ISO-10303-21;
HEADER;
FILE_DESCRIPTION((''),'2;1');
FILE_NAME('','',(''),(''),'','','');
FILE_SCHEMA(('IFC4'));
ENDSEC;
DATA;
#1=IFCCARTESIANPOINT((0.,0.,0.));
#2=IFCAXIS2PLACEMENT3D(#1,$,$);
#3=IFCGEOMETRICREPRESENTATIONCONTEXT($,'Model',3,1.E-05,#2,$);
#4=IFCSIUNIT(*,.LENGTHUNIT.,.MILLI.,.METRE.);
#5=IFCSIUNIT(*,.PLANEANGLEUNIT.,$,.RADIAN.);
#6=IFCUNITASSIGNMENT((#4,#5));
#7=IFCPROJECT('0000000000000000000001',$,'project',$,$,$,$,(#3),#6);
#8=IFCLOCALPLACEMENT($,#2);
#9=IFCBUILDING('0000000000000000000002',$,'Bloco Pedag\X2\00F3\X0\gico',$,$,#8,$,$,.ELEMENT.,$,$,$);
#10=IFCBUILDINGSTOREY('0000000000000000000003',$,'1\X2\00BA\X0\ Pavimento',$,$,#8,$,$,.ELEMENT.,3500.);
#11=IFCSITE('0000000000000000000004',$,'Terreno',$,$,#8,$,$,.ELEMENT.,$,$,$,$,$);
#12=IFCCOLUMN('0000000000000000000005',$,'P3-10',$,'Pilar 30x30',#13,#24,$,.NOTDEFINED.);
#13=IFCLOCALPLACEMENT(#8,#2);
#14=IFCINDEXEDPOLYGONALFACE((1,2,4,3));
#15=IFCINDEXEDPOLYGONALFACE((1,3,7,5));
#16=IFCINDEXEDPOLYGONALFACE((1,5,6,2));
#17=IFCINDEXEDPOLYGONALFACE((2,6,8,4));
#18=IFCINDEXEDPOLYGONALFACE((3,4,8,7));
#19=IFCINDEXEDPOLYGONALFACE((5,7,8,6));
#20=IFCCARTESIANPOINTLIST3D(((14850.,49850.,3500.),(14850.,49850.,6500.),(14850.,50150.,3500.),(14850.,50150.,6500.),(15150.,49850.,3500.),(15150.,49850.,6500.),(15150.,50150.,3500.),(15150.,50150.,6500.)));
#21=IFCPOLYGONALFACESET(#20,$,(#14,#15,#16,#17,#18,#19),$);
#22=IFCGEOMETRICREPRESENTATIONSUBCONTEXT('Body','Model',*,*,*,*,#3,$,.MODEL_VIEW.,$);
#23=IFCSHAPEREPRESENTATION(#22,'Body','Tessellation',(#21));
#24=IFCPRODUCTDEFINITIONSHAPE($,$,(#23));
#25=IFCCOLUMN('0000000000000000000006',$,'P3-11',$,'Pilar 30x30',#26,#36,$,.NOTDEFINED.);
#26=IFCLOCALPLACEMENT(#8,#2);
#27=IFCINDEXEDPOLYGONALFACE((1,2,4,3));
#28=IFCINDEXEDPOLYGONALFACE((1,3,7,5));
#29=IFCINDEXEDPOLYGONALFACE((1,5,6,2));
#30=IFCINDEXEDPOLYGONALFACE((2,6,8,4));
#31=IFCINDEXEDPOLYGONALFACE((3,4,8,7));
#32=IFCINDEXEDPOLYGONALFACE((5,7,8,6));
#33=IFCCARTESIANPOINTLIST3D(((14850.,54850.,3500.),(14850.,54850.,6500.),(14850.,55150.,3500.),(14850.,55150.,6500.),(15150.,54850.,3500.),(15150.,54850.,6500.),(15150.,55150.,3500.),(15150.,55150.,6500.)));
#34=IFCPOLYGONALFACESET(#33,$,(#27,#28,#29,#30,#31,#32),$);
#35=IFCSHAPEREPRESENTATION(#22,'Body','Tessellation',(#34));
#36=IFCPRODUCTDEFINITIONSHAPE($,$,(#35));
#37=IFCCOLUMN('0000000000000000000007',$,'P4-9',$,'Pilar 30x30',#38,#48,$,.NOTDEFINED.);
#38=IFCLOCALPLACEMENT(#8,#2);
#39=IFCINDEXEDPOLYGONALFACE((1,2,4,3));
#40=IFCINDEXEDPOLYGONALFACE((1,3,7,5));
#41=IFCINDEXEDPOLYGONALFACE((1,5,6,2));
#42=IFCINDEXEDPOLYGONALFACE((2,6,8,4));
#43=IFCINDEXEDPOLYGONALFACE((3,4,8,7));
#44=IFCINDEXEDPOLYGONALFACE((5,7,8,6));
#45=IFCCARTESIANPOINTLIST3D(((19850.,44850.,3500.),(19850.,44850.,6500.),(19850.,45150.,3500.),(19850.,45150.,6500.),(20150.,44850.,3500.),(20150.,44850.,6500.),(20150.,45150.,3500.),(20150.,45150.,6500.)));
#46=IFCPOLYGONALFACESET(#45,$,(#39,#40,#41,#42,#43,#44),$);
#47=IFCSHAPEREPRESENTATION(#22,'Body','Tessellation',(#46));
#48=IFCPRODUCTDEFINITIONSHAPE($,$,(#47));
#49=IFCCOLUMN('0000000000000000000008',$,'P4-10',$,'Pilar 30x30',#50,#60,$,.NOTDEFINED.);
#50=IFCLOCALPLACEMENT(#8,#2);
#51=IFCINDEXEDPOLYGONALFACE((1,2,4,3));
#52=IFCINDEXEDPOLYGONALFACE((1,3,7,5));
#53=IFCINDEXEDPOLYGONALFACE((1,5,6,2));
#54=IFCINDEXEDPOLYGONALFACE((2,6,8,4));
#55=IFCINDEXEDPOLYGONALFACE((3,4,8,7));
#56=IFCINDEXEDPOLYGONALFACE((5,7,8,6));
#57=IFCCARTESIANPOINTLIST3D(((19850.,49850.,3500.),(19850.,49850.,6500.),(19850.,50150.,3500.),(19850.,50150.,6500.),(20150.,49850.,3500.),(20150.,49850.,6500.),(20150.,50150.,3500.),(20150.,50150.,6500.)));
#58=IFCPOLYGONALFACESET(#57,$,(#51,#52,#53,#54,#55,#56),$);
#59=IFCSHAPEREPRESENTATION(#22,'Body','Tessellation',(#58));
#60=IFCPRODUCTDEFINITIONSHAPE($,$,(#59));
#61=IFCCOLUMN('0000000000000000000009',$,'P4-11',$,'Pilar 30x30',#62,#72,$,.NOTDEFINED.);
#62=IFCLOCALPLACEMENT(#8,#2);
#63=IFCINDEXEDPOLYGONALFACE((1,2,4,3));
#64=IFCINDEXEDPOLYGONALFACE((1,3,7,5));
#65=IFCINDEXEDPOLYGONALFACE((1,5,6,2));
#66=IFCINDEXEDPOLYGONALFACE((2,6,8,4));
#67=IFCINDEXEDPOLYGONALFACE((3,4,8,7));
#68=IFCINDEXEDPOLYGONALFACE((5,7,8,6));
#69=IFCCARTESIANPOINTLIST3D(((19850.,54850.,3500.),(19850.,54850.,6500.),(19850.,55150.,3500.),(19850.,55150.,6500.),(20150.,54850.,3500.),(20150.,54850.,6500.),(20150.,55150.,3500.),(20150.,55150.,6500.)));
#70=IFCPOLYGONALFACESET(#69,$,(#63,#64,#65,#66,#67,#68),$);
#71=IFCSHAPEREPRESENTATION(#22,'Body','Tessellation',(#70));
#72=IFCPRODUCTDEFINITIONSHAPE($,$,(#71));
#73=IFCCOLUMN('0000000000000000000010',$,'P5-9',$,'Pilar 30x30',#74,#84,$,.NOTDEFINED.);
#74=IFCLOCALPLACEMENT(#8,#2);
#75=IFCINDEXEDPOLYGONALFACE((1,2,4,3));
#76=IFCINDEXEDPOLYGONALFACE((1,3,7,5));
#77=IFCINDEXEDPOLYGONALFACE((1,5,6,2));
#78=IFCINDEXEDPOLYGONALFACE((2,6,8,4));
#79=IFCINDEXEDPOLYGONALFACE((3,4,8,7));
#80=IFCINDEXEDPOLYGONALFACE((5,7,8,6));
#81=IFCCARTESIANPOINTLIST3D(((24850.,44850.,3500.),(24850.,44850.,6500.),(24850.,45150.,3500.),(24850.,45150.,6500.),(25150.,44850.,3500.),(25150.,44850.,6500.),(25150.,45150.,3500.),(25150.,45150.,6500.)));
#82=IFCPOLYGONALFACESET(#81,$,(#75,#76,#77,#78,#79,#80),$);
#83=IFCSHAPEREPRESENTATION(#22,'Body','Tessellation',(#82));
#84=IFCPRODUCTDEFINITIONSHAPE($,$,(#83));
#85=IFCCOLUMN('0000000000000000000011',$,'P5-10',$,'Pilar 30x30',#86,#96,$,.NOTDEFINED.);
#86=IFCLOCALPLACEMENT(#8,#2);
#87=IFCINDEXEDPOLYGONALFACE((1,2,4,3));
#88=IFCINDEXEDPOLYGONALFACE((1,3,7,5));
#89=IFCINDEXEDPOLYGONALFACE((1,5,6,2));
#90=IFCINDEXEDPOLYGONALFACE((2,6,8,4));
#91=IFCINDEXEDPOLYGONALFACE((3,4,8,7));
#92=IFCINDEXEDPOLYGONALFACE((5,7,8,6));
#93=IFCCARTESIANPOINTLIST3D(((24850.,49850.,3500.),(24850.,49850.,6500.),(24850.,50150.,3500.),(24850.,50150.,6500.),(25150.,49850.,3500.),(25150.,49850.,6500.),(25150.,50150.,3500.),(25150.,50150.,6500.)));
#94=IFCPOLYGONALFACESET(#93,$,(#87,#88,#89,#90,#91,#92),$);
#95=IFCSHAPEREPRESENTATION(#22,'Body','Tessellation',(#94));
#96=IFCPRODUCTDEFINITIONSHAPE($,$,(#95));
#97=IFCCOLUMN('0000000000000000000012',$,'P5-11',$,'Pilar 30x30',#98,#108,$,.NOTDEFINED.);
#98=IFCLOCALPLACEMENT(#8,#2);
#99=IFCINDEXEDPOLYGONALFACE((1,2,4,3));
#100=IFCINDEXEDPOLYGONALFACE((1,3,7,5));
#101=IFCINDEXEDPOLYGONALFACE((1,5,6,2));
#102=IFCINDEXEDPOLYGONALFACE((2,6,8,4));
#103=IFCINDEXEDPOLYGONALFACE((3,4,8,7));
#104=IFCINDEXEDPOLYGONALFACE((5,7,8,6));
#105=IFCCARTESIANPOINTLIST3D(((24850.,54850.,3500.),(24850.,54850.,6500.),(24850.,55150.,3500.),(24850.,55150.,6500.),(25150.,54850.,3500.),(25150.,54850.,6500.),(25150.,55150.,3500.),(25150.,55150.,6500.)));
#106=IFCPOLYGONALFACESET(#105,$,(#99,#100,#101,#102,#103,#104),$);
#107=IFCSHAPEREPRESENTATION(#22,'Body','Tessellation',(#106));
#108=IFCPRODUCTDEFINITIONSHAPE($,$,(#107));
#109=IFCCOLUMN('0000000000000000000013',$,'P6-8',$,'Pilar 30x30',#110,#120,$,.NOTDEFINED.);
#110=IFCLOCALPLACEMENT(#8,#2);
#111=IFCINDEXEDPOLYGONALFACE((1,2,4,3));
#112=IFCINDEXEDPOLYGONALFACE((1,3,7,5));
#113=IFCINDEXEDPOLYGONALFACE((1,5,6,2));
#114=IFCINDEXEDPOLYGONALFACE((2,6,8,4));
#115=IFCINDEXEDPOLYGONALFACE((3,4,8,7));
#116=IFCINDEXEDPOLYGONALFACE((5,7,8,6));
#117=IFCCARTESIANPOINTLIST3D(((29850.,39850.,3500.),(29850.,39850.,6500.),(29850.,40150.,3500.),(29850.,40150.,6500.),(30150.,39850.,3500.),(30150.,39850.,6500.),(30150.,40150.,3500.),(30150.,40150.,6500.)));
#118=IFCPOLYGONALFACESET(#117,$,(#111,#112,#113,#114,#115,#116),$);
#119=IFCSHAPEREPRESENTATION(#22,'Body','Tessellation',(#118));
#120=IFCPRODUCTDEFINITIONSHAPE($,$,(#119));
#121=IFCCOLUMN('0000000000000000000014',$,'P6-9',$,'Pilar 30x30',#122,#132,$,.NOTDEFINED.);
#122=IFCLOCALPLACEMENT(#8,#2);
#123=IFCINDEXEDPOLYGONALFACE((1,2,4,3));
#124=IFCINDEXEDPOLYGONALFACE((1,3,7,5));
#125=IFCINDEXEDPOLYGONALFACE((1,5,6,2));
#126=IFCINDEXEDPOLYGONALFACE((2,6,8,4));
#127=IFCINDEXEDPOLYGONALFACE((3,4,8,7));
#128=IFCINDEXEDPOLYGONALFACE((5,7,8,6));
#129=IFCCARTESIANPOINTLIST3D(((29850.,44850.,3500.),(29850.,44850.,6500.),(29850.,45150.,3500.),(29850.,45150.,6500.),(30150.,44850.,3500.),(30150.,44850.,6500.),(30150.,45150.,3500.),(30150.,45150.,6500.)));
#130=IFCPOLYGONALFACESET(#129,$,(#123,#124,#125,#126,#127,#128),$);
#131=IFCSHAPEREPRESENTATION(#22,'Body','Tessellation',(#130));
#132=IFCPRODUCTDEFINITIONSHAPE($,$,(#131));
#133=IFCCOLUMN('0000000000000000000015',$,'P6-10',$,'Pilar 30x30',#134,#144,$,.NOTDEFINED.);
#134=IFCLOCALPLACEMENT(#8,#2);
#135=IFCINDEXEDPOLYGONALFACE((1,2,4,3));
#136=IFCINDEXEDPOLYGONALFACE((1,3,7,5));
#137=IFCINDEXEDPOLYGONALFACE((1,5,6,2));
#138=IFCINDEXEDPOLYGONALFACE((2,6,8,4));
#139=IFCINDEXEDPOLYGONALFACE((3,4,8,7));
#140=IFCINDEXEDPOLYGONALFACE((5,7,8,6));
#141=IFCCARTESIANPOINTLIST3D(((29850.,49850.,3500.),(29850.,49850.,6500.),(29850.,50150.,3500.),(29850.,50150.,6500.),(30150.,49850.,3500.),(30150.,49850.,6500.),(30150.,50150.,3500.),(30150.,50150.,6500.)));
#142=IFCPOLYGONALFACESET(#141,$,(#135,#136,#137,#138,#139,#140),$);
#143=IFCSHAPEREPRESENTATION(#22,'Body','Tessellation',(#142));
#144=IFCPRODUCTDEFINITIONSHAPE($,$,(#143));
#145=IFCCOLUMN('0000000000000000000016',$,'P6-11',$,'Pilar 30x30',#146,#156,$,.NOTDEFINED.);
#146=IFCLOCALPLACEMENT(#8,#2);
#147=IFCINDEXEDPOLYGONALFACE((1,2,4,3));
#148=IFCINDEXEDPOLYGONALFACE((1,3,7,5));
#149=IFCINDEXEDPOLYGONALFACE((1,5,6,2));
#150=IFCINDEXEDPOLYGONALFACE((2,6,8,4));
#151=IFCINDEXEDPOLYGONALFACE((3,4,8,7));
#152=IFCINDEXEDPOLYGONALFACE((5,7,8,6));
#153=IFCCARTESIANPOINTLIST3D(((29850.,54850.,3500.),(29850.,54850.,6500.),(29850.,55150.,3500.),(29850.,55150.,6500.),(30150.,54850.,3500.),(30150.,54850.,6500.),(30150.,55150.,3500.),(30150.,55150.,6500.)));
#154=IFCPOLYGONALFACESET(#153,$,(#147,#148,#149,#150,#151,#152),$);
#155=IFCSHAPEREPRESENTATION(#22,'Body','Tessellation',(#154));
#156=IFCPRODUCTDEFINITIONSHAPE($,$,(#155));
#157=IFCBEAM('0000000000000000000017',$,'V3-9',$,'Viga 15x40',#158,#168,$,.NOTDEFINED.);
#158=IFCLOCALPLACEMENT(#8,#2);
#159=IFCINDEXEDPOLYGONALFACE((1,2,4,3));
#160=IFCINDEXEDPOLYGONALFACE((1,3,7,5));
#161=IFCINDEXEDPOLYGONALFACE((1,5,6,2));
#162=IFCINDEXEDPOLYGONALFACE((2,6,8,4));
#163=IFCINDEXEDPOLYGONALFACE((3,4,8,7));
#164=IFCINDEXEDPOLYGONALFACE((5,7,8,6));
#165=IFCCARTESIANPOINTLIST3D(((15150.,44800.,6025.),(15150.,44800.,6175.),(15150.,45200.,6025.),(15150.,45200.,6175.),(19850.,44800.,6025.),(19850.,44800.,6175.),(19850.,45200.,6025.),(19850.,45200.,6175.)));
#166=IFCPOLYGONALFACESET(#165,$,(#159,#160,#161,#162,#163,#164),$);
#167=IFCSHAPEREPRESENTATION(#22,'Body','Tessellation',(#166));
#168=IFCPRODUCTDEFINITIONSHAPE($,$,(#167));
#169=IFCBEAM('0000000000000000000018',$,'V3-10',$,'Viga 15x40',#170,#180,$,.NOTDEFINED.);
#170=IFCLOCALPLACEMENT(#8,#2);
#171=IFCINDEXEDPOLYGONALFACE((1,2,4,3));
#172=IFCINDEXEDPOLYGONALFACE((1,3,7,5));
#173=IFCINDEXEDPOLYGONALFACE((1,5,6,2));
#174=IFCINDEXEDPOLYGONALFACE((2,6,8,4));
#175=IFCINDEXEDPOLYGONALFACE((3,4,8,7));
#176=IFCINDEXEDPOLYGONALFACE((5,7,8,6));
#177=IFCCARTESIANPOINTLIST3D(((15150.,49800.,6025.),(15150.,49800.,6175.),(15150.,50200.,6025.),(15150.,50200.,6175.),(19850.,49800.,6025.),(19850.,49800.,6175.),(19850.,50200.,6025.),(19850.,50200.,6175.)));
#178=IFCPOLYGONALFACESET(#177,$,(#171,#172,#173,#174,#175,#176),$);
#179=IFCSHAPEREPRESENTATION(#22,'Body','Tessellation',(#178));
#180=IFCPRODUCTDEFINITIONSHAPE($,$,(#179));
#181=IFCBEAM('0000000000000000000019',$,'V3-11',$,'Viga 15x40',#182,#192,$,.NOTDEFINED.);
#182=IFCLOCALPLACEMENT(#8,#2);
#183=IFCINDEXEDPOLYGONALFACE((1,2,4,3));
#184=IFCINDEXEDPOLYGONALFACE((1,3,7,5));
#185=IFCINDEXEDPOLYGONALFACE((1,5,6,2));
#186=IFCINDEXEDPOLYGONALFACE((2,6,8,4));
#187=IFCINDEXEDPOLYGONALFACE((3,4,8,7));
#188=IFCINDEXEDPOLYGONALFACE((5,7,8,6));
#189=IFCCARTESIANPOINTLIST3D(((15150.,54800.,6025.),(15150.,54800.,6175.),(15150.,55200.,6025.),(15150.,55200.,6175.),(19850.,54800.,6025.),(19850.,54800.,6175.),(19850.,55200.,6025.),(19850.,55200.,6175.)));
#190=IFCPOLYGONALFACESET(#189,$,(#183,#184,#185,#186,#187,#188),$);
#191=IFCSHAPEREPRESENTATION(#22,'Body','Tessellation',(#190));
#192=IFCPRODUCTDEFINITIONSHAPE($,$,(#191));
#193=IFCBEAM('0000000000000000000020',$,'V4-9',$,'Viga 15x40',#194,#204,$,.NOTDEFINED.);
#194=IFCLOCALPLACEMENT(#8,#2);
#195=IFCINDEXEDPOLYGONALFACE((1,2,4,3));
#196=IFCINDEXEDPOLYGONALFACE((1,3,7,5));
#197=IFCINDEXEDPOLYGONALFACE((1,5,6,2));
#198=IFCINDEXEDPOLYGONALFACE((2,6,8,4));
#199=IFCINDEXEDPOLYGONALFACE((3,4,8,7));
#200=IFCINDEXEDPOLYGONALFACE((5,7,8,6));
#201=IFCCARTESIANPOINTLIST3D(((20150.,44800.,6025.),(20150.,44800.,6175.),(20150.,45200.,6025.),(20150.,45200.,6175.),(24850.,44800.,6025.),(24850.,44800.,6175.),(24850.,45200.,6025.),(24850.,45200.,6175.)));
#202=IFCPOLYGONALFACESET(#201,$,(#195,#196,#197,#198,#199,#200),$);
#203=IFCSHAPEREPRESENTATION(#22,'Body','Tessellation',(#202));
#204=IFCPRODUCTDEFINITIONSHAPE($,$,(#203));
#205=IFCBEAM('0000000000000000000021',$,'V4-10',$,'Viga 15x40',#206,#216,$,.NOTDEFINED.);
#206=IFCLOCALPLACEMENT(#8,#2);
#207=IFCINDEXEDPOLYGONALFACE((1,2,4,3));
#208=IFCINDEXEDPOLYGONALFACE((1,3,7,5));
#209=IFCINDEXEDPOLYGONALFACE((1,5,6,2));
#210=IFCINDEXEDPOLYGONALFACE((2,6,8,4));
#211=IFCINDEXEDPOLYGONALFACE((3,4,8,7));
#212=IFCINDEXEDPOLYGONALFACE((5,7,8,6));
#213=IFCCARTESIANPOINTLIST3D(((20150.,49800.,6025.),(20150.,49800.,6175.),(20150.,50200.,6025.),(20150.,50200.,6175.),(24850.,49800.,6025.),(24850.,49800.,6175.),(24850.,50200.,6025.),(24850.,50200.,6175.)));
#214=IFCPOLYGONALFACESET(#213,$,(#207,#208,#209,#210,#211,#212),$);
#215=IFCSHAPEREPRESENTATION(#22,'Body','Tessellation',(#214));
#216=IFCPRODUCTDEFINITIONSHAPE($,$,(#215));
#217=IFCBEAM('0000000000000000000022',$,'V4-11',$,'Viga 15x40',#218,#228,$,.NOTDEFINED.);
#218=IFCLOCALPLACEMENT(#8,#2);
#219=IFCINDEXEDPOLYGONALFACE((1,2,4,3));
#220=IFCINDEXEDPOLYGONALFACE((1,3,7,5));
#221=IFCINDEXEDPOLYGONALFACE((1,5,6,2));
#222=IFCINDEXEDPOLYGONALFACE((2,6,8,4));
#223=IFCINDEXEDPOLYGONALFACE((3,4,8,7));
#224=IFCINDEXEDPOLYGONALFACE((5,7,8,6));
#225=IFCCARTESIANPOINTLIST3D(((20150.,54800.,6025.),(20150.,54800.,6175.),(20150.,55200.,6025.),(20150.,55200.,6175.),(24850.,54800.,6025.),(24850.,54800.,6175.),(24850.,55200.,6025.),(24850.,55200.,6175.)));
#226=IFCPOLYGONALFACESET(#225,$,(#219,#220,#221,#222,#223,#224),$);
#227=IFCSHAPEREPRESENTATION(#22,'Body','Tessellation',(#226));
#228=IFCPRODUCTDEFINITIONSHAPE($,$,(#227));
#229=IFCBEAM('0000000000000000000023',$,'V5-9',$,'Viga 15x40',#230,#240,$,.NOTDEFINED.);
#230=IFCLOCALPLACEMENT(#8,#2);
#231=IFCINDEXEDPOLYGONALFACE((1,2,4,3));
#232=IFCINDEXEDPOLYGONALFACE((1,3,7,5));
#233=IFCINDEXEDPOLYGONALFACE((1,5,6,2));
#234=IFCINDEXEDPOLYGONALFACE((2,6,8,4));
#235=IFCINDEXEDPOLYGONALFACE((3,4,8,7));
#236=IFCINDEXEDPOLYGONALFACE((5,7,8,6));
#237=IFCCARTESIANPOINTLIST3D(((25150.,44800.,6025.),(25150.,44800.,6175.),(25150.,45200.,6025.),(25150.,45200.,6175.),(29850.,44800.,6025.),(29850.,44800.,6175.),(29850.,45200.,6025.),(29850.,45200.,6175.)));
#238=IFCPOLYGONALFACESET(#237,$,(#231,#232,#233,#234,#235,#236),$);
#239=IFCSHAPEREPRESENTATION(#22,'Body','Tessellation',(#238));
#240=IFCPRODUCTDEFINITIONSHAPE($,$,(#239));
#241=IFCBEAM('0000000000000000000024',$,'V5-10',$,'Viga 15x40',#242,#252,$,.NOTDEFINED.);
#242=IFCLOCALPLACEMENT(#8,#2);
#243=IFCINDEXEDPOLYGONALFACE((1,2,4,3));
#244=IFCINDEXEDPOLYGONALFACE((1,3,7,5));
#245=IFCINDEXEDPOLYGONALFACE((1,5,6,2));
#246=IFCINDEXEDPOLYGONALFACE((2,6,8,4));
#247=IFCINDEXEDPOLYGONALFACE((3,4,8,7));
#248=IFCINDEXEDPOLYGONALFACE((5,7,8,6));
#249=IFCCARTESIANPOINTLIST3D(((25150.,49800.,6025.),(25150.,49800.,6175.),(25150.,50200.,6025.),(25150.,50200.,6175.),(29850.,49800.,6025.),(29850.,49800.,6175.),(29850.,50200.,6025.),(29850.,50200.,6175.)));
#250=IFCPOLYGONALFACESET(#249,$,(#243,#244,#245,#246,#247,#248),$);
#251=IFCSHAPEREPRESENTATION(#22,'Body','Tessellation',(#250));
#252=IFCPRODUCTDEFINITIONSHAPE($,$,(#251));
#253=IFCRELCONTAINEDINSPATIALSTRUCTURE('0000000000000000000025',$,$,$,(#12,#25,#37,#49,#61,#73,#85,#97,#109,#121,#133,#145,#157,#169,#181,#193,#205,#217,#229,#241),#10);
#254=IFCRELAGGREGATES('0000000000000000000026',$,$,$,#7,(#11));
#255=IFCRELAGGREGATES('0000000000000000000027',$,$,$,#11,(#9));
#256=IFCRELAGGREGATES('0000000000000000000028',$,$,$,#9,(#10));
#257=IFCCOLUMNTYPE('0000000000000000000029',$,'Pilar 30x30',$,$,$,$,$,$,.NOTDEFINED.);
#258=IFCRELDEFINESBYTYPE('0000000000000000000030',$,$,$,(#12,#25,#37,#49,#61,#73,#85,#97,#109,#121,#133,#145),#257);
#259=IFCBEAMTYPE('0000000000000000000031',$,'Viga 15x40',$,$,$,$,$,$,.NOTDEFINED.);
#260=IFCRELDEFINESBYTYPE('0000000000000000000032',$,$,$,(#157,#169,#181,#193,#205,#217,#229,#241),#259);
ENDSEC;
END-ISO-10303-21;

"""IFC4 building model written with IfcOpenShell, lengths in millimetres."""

from ifc_helpers import new_model, si_unit, frame, origin, origin_2d, place, context, subcontext, project, spatial, rectangle, extrude, type_object, element, save


model = new_model("IFC4")

# Units and contexts
model_context = context("Model", 3, precision=1e-05, world=origin())
body_context = subcontext(model_context, "Body", "Model", "MODEL_VIEW")
ifc_project = project(units=[si_unit("LENGTHUNIT", "METRE", prefix="MILLI"), si_unit("PLANEANGLEUNIT", "RADIAN")], contexts=[model_context])

# Site, building, storey
placement = place(None, origin())
site = spatial("IfcSite", under=ifc_project, at=placement, Name="Terreno", CompositionType="ELEMENT")
building = spatial("IfcBuilding", under=site, at=placement, Name="Bloco Pedagógico", CompositionType="ELEMENT")
storey = spatial("IfcBuildingStorey", under=building, at=placement, Name="1º Pavimento", CompositionType="ELEMENT", Elevation=3500.0)

# Columns
column_type = type_object("IfcColumnType", Name="Pilar 30x30", PredefinedType="NOTDEFINED")
for number, where, z_axis, x_axis, name in (
    (1, (15000.0, 50000.0, 3500.0), (0.0, 0.0, 1.0), (1.0, 0.0, 0.0), "P3-10"),
    (2, (15000.0, 55000.0, 3500.0), (0.0, 0.0, 1.0), (1.0, 0.0, 0.0), "P3-11"),
    (3, (20000.0, 45000.0, 3500.0), (0.0, 0.0, 1.0), (1.0, 0.0, 0.0), "P4-9"),
    (4, (20000.0, 50000.0, 3500.0), (0.0, 0.0, 1.0), (1.0, 0.0, 0.0), "P4-10"),
    (5, (20000.0, 55000.0, 3500.0), (0.0, 0.0, 1.0), (1.0, 0.0, 0.0), "P4-11"),
    (6, (25000.0, 45000.0, 3500.0), (0.0, 0.0, 1.0), (1.0, 0.0, 0.0), "P5-9"),
    (7, (25000.0, 50000.0, 3500.0), (0.0, 0.0, 1.0), (1.0, 0.0, 0.0), "P5-10"),
    (8, (25000.0, 55000.0, 3500.0), (0.0, 0.0, 1.0), (1.0, 0.0, 0.0), "P5-11"),
    (9, (30000.0, 40000.0, 3500.0), (0.0, 0.0, 1.0), (1.0, 0.0, 0.0), "P6-8"),
    (10, (30000.0, 45000.0, 3500.0), (0.0, 0.0, 1.0), (1.0, 0.0, 0.0), "P6-9"),
    (11, (30000.0, 50000.0, 3500.0), (0.0, 0.0, 1.0), (1.0, 0.0, 0.0), "P6-10"),
    (12, (30000.0, 55000.0, 3500.0), (0.0, 0.0, 1.0), (1.0, 0.0, 0.0), "P6-11"),
):
    element("IfcColumn", number, at=place(None, frame(where, z_axis=z_axis, x_axis=x_axis)), inside=storey, type_object=column_type, Name=name, ObjectType="Pilar 30x30", PredefinedType="NOTDEFINED", context=body_context, shape_type="SweptSolid", body=[
        extrude(rectangle(XDim=300.0, YDim=300.0, at=origin_2d()), None, (0.0, 0.0, 1.0), 3000.0),
    ])

# Beams
beam_type = type_object("IfcBeamType", Name="Viga 15x40", PredefinedType="NOTDEFINED")
for number, where, z_axis, x_axis, name in (
    (13, (15150.0, 45000.0, 6100.0), (1.0, 0.0, 0.0), (0.0, 1.0, 0.0), "V3-9"),
    (14, (15150.0, 50000.0, 6100.0), (1.0, 0.0, 0.0), (0.0, 1.0, 0.0), "V3-10"),
    (15, (15150.0, 55000.0, 6100.0), (1.0, 0.0, 0.0), (0.0, 1.0, 0.0), "V3-11"),
    (16, (20150.0, 45000.0, 6100.0), (1.0, 0.0, 0.0), (0.0, 1.0, 0.0), "V4-9"),
    (17, (20150.0, 50000.0, 6100.0), (1.0, 0.0, 0.0), (0.0, 1.0, 0.0), "V4-10"),
    (18, (20150.0, 55000.0, 6100.0), (1.0, 0.0, 0.0), (0.0, 1.0, 0.0), "V4-11"),
    (19, (25150.0, 45000.0, 6100.0), (1.0, 0.0, 0.0), (0.0, 1.0, 0.0), "V5-9"),
    (20, (25150.0, 50000.0, 6100.0), (1.0, 0.0, 0.0), (0.0, 1.0, 0.0), "V5-10"),
):
    element("IfcBeam", number, at=place(None, frame(where, z_axis=z_axis, x_axis=x_axis)), inside=storey, type_object=beam_type, Name=name, ObjectType="Viga 15x40", PredefinedType="NOTDEFINED", context=body_context, shape_type="SweptSolid", body=[
        extrude(rectangle(XDim=400.0, YDim=150.0, at=origin_2d()), None, (0.0, 0.0, 1.0), 4700.0),
    ])

save(model, "model.ifc")
